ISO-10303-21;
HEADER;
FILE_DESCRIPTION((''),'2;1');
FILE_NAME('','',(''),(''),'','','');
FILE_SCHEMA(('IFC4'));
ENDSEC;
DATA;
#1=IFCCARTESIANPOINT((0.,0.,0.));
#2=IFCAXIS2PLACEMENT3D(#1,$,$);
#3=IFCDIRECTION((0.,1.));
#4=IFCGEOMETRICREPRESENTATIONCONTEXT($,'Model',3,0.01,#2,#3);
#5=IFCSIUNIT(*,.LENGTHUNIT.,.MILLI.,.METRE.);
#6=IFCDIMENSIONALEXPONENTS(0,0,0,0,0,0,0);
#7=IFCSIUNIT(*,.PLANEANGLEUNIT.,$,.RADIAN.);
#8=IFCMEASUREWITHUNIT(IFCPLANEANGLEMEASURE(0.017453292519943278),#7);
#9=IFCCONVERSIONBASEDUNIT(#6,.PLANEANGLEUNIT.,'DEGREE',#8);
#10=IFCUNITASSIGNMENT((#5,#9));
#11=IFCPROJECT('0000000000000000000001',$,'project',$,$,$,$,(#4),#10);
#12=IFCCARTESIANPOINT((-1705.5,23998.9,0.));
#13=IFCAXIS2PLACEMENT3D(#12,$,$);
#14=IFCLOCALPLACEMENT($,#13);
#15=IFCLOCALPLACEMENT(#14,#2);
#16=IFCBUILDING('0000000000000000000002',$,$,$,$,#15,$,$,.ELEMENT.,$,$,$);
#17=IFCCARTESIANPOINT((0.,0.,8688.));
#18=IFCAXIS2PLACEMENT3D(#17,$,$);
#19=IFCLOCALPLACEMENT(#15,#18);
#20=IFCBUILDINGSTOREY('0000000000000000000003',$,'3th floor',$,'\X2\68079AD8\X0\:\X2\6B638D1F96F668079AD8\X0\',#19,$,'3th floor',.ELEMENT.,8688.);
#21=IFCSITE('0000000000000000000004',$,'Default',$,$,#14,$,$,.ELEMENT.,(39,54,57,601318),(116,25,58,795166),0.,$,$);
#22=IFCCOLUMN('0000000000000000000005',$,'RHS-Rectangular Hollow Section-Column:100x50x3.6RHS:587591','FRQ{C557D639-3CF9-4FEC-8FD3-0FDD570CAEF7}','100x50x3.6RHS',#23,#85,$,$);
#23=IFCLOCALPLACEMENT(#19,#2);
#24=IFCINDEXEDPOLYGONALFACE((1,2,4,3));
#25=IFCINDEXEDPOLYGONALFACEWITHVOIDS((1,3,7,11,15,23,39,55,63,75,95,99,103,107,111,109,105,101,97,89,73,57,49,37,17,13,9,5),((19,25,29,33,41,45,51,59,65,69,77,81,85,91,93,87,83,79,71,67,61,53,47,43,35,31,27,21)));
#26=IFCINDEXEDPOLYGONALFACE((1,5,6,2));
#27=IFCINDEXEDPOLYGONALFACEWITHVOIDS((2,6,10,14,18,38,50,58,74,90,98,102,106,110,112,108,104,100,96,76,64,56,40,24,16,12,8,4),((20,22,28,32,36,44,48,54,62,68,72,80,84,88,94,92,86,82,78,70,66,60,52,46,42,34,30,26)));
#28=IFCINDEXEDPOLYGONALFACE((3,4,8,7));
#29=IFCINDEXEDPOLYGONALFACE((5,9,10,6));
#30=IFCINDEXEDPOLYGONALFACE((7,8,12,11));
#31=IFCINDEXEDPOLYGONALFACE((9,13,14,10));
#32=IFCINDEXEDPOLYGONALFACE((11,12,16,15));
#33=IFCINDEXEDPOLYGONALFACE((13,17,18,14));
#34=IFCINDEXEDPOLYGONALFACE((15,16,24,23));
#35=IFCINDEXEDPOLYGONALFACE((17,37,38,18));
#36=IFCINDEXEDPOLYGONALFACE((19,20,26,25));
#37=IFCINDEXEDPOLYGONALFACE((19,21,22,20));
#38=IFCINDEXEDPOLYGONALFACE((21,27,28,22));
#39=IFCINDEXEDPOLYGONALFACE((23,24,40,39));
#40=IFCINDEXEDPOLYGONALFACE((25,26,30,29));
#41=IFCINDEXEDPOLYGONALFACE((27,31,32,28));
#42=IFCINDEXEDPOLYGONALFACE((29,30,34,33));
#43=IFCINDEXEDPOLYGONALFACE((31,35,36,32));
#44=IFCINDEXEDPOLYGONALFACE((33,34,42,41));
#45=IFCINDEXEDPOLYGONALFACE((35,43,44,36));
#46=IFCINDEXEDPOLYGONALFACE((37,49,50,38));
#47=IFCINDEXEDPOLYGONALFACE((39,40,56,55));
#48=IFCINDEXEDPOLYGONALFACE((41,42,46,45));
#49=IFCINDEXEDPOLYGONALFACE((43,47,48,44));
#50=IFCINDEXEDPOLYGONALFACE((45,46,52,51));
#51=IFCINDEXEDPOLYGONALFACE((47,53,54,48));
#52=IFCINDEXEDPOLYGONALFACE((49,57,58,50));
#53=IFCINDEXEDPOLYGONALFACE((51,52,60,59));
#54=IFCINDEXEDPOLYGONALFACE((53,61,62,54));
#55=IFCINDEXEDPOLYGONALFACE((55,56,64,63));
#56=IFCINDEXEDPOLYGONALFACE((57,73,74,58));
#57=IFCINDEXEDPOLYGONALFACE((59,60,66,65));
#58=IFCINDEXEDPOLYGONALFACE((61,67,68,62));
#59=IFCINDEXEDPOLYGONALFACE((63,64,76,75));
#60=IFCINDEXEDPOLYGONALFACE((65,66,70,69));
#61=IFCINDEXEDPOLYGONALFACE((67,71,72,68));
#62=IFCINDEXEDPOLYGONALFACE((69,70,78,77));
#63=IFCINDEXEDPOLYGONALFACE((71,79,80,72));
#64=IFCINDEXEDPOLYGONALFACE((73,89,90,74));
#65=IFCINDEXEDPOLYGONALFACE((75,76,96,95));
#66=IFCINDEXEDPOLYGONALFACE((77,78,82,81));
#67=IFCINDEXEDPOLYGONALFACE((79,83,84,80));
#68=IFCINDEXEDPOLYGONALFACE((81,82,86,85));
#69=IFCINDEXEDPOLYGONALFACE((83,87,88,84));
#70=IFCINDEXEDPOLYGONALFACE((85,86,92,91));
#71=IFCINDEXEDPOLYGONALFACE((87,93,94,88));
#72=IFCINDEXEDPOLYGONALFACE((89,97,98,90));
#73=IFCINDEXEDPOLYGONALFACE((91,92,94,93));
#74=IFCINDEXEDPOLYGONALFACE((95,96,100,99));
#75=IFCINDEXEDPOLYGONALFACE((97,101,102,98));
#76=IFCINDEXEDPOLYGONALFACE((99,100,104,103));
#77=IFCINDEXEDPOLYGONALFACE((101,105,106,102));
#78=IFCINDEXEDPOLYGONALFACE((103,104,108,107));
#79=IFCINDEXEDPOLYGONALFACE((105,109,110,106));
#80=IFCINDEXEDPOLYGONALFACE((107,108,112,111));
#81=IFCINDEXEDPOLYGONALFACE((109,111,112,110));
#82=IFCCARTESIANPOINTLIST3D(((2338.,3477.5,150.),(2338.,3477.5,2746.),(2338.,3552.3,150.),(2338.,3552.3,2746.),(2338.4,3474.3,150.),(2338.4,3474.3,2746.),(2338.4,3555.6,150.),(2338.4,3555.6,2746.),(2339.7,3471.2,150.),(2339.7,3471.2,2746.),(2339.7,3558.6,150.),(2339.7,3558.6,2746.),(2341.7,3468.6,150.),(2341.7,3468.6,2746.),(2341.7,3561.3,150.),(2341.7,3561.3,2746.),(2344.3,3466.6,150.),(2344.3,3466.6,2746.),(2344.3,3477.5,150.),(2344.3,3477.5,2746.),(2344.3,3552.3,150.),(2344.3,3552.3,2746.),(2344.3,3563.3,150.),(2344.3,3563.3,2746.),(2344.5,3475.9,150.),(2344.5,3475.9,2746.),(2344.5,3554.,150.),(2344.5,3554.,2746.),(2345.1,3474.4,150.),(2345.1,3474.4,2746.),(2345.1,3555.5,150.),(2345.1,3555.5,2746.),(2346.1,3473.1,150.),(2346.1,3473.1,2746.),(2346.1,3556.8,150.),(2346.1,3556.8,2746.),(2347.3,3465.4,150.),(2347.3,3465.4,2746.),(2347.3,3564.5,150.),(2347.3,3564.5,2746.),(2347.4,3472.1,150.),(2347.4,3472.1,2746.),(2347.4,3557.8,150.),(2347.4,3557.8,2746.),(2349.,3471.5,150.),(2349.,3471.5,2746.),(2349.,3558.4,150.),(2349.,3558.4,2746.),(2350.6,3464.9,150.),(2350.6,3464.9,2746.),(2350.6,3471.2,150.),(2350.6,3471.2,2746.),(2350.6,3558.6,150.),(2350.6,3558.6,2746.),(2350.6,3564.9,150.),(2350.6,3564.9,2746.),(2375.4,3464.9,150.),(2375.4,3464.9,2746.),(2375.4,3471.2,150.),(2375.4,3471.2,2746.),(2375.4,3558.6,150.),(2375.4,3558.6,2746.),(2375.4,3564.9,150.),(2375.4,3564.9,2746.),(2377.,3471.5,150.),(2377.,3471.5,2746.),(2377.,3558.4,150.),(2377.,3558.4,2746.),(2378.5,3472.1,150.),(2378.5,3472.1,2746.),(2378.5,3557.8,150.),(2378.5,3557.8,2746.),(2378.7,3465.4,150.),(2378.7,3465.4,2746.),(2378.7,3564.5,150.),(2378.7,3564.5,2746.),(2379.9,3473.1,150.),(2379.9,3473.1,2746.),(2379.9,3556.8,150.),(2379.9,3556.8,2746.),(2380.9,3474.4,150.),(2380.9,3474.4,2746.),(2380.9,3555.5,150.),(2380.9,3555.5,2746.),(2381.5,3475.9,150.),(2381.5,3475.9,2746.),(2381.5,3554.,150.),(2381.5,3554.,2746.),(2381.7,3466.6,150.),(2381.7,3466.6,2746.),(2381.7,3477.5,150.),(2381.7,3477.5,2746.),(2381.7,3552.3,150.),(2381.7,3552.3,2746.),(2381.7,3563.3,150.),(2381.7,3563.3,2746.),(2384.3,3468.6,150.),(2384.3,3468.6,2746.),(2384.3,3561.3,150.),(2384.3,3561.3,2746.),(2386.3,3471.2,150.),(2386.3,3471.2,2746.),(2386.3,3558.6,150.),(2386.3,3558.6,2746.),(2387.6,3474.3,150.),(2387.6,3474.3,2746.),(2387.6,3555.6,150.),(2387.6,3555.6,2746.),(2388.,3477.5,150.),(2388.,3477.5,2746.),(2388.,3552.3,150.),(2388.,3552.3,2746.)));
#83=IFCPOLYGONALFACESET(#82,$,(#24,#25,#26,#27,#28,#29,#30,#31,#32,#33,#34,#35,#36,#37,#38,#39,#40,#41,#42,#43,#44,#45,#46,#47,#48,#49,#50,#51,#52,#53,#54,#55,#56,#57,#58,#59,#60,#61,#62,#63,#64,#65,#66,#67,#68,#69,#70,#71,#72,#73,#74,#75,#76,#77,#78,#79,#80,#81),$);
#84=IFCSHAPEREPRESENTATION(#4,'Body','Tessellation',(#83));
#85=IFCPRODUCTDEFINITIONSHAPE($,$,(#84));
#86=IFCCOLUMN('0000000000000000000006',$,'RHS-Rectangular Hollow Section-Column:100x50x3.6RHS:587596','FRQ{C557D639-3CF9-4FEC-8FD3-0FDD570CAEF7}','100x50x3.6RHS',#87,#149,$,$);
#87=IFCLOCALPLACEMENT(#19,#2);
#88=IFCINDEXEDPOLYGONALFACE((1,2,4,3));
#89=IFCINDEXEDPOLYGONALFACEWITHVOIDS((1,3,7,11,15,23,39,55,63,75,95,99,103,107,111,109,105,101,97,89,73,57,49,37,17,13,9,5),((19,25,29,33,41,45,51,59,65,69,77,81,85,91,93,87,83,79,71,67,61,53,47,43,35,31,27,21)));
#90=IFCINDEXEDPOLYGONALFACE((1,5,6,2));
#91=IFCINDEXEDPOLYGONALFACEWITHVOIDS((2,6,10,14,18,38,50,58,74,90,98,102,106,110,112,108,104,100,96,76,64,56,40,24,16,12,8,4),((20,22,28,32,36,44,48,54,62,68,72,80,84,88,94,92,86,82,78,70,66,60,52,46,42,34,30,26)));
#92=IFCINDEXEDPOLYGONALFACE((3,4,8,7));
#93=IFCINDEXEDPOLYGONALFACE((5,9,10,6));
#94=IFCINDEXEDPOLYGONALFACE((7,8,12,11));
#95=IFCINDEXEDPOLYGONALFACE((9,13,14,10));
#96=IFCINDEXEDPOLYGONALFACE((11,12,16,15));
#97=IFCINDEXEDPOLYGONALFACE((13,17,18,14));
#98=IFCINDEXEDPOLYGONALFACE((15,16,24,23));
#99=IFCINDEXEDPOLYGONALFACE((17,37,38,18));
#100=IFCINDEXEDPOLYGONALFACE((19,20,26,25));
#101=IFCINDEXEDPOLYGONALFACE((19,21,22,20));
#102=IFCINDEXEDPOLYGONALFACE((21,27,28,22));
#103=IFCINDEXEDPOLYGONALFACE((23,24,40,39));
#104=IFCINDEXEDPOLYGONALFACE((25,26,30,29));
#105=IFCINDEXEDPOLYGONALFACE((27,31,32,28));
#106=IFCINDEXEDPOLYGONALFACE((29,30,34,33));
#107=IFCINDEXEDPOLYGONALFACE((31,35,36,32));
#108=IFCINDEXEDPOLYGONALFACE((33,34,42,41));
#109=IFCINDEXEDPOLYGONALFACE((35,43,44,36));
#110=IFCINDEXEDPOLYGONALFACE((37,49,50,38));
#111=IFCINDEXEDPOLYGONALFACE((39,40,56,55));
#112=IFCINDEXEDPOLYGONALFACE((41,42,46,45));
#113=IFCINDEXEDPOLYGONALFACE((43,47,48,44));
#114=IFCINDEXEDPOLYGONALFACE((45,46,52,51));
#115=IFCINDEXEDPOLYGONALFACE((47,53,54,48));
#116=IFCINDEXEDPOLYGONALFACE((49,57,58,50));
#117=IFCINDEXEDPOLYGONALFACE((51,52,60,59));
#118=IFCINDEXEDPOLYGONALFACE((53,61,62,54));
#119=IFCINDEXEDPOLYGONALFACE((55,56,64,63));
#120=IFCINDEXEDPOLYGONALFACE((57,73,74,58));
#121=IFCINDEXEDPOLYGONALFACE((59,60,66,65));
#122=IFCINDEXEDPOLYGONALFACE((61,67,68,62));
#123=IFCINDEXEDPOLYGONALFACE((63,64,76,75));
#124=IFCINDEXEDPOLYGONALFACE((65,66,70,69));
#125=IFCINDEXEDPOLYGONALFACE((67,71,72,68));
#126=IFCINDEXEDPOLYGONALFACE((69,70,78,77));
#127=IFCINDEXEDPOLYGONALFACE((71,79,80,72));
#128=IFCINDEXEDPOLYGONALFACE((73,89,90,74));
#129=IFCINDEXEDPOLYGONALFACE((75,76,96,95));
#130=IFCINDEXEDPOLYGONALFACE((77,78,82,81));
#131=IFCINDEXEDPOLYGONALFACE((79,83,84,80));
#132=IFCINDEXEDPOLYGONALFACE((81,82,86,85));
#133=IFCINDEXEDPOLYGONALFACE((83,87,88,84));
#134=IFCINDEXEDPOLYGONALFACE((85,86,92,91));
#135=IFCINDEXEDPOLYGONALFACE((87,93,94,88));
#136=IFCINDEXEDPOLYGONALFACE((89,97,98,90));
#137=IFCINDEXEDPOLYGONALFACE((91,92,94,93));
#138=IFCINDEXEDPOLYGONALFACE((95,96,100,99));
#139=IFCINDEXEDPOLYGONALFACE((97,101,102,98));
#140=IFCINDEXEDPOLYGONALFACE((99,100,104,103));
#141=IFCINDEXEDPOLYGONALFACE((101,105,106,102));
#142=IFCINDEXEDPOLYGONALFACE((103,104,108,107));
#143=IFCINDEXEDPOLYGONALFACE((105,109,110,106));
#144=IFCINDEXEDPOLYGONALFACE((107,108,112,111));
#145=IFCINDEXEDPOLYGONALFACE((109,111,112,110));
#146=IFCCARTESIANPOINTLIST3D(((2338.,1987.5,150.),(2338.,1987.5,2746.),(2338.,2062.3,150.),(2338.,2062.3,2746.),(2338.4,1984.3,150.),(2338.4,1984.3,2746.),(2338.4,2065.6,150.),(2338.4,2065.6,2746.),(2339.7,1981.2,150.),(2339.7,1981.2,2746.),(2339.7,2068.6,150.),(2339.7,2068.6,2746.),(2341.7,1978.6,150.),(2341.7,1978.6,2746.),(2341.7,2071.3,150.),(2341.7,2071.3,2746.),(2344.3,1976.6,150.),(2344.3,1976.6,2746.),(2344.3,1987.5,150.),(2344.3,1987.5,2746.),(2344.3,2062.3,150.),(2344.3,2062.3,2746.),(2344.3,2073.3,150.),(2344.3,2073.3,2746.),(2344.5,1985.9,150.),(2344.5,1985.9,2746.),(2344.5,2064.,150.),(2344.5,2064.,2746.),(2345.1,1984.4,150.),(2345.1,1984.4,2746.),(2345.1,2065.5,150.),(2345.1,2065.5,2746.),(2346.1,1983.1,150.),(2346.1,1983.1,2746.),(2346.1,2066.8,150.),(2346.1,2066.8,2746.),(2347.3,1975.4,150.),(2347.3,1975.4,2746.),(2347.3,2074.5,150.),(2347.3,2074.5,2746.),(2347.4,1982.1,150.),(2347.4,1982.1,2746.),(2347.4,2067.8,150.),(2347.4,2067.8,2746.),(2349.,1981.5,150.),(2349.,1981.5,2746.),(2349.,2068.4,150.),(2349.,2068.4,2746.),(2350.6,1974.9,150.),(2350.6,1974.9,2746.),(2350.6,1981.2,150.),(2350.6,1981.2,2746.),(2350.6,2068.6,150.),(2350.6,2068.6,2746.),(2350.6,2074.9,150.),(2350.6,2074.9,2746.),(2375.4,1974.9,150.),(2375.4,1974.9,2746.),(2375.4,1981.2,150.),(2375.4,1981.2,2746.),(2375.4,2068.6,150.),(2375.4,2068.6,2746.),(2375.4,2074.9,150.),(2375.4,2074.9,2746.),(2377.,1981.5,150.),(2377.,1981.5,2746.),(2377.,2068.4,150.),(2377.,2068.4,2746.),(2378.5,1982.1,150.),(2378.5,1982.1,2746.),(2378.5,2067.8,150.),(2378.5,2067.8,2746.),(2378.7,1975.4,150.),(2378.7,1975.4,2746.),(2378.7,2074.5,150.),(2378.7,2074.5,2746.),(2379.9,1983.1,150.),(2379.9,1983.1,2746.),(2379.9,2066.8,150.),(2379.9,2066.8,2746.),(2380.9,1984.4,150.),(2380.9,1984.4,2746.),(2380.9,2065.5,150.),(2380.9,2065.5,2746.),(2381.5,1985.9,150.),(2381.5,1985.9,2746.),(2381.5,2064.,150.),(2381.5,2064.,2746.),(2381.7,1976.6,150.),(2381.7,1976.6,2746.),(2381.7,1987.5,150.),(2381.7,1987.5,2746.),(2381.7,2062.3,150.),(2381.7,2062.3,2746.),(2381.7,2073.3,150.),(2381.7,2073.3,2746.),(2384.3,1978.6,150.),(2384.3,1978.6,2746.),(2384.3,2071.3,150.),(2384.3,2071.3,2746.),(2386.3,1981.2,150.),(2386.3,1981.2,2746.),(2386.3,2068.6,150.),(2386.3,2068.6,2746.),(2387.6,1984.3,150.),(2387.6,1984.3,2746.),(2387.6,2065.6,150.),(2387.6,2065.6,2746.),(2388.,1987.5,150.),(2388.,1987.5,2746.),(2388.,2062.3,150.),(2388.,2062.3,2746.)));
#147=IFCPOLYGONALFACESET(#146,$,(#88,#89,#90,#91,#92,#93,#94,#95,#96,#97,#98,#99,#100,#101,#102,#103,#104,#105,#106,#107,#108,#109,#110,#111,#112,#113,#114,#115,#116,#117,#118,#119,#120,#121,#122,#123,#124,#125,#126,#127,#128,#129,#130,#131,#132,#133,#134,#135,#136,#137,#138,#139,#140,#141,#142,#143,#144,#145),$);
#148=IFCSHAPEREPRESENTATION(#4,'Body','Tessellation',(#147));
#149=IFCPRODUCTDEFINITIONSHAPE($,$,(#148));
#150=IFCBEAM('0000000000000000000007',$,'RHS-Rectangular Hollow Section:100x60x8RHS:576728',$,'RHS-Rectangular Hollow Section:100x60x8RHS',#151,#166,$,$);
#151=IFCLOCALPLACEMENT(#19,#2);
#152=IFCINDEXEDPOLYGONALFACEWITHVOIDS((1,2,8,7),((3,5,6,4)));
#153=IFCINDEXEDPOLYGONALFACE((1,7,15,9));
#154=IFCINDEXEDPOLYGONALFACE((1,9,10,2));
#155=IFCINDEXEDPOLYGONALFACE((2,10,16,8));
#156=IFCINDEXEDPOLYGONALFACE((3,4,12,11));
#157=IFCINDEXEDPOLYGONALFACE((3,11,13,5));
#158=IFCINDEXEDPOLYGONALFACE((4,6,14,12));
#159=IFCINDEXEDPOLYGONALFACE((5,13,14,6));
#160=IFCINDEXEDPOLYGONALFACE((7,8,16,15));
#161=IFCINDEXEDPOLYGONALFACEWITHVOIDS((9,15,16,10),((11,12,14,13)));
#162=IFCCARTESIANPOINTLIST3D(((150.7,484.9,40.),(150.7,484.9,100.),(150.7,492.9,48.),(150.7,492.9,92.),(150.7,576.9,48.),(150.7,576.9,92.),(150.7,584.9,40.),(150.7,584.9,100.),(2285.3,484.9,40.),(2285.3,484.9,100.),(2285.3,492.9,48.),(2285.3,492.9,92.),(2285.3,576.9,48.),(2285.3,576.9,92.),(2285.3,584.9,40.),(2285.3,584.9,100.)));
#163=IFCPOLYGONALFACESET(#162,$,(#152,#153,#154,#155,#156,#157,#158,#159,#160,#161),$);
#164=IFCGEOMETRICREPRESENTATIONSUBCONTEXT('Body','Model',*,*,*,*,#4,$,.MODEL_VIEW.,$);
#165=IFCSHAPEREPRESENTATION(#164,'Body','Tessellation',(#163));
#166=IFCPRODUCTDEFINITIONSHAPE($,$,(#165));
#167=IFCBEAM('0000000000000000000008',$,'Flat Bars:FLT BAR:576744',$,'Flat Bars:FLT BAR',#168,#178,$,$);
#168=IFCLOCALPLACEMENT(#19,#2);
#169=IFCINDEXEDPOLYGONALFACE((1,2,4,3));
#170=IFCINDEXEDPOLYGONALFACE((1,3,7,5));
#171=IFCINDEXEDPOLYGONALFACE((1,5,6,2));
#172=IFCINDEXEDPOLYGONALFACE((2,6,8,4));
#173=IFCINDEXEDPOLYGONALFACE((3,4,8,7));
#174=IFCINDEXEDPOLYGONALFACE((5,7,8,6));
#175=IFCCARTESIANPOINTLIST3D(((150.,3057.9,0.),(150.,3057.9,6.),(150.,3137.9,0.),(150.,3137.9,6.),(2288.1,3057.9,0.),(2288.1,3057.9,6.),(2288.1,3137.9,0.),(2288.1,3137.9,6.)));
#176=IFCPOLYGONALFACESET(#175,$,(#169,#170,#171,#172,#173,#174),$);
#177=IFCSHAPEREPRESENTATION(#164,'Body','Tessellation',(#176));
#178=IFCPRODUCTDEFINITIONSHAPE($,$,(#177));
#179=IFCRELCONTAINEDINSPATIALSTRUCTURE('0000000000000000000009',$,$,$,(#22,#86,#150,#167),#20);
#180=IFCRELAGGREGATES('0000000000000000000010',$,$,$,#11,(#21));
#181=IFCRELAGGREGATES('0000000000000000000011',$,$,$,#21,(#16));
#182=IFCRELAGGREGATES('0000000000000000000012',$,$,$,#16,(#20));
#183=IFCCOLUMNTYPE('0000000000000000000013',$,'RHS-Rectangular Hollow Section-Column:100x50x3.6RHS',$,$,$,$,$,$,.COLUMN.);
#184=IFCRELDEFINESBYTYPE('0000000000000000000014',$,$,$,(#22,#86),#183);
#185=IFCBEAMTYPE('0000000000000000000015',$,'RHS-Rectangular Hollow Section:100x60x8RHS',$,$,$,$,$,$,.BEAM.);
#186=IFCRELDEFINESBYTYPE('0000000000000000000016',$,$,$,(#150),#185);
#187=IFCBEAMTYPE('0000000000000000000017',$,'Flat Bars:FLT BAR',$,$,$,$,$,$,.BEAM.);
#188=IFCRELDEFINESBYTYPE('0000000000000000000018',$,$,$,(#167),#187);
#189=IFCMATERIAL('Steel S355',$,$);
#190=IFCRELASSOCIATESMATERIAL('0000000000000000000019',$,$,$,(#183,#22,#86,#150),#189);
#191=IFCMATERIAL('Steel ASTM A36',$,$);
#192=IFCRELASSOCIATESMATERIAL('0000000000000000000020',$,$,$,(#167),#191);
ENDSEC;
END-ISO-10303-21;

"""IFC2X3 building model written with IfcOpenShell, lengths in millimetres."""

from ifc_helpers import new_model, entity, si_unit, converted_unit, direction, frame, frame_2d, origin, origin_2d, origin_2d_with_axis, place, context, subcontext, project, spatial, rectangle, hollow_rectangle, extrude, boolean, clip, halfspace, material, type_object, element, save


model = new_model("IFC2X3")

# Units and contexts
model_context = context("Model", 3, precision=0.01, world=origin(), true_north=direction((0.0, 1.0)))
body_context = subcontext(model_context, "Body", "Model", "MODEL_VIEW")
ifc_project = project(units=[si_unit("LENGTHUNIT", "METRE", prefix="MILLI"), converted_unit("PLANEANGLEUNIT", "DEGREE", entity("IfcPlaneAngleMeasure", 0.017453292519943278), si_unit("PLANEANGLEUNIT", "RADIAN"), dimensions=[0, 0, 0, 0, 0, 0, 0])], contexts=[model_context])

# Site, building, storey
site_placement = place(None, frame((-1705.5, 23998.9, 0.0)))
site = spatial("IfcSite", under=ifc_project, at=site_placement, Name="Default", CompositionType="ELEMENT", RefLatitude=(39, 54, 57, 601318), RefLongitude=(116, 25, 58, 795166), RefElevation=0.0)
building_placement = place(site_placement, origin())
building = spatial("IfcBuilding", under=site, at=building_placement, CompositionType="ELEMENT")
storey_placement = place(building_placement, frame((0.0, 0.0, 8688.0)))
storey = spatial("IfcBuildingStorey", under=building, at=storey_placement, Name="3th floor", ObjectType="标高:正负零标高", LongName="3th floor", CompositionType="ELEMENT", Elevation=8688.0)

# Shared definitions
ifc_material_1 = material(Name="Steel S355")

# Columns
column_type_1 = type_object("IfcColumnType", Name="RHS-Rectangular Hollow Section-Column:100x50x3.6RHS", PredefinedType="COLUMN", material=ifc_material_1)
column_1_placement = place(storey_placement, frame((2363.0, 3514.9, 2746.0)))
element("IfcColumn", 1, at=column_1_placement, inside=storey, type_object=column_type_1, material=ifc_material_1, Name="RHS-Rectangular Hollow Section-Column:100x50x3.6RHS:587591", Description="FRQ{C557D639-3CF9-4FEC-8FD3-0FDD570CAEF7}", ObjectType="100x50x3.6RHS", context=model_context, shape_type="Clipping", body=[
    clip(extrude(hollow_rectangle(XDim=50.0, YDim=100.0, WallThickness=6.3, InnerFilletRadius=6.3, OuterFilletRadius=12.6, at=origin_2d()), origin(), (0.0, 0.0, -1.0), 2651.9), halfspace(frame((-2363.0, -3514.9, -2596.0), z_axis=(0.0, 0.0, 1.0), x_axis=(1.0, 0.0, 0.0)), True)),
])
column_2_placement = place(storey_placement, frame((2363.0, 2024.9, 2746.0)))
element("IfcColumn", 2, at=column_2_placement, inside=storey, type_object=column_type_1, material=ifc_material_1, Name="RHS-Rectangular Hollow Section-Column:100x50x3.6RHS:587596", Description="FRQ{C557D639-3CF9-4FEC-8FD3-0FDD570CAEF7}", ObjectType="100x50x3.6RHS", context=model_context, shape_type="Clipping", body=[
    clip(extrude(hollow_rectangle(XDim=50.0, YDim=100.0, WallThickness=6.3, InnerFilletRadius=6.3, OuterFilletRadius=12.6, at=origin_2d()), origin(), (0.0, 0.0, -1.0), 2651.9), halfspace(frame((-2363.0, -2024.9, -2596.0), z_axis=(0.0, 0.0, 1.0), x_axis=(1.0, 0.0, 0.0)), True)),
])

# Beams
beam_type_1 = type_object("IfcBeamType", Name="RHS-Rectangular Hollow Section:100x60x8RHS", PredefinedType="BEAM")
beam_1_placement = place(storey_placement, frame((150.7, 584.9, 70.0)))
element("IfcBeam", 3, at=beam_1_placement, inside=storey, type_object=beam_type_1, material=ifc_material_1, Name="RHS-Rectangular Hollow Section:100x60x8RHS:576728", ObjectType="RHS-Rectangular Hollow Section:100x60x8RHS", context=body_context, shape_type="SweptSolid", body=[
    boolean("DIFFERENCE", extrude(rectangle(XDim=60.0, YDim=100.0, at=frame_2d((0.0, 0.0), x_axis=(1.0, 0.0))), frame((0.0, -50.0, 0.0), z_axis=(1.0, 0.0, 0.0), x_axis=(0.0, 0.0, -1.0)), (0.0, 0.0, 1.0), 2134.6), extrude(rectangle(XDim=44.0, YDim=84.0, at=frame_2d((0.0, 0.0), x_axis=(0.0, 1.0))), frame((2134.6, -50.0, 0.0), z_axis=(-1.0, 0.0, 0.0), x_axis=(0.0, 1.0, 0.0)), (0.0, 0.0, 1.0), 2134.6)),
])
ifc_material_2 = material(Name="Steel ASTM A36")
beam_type_2 = type_object("IfcBeamType", Name="Flat Bars:FLT BAR", PredefinedType="BEAM")
beam_2_placement = place(storey_placement, frame((150.0, 3097.9, 6.0)))
element("IfcBeam", 4, at=beam_2_placement, inside=storey, type_object=beam_type_2, material=ifc_material_2, Name="Flat Bars:FLT BAR:576744", ObjectType="Flat Bars:FLT BAR", context=body_context, shape_type="SweptSolid", body=[
    extrude(rectangle(XDim=6.0, YDim=80.0, at=origin_2d_with_axis()), frame((0.0, 0.0, -3.0), z_axis=(1.0, 0.0, 0.0), x_axis=(0.0, 0.0, -1.0)), (0.0, 0.0, 1.0), 2138.1),
])

save(model, "model.ifc")
